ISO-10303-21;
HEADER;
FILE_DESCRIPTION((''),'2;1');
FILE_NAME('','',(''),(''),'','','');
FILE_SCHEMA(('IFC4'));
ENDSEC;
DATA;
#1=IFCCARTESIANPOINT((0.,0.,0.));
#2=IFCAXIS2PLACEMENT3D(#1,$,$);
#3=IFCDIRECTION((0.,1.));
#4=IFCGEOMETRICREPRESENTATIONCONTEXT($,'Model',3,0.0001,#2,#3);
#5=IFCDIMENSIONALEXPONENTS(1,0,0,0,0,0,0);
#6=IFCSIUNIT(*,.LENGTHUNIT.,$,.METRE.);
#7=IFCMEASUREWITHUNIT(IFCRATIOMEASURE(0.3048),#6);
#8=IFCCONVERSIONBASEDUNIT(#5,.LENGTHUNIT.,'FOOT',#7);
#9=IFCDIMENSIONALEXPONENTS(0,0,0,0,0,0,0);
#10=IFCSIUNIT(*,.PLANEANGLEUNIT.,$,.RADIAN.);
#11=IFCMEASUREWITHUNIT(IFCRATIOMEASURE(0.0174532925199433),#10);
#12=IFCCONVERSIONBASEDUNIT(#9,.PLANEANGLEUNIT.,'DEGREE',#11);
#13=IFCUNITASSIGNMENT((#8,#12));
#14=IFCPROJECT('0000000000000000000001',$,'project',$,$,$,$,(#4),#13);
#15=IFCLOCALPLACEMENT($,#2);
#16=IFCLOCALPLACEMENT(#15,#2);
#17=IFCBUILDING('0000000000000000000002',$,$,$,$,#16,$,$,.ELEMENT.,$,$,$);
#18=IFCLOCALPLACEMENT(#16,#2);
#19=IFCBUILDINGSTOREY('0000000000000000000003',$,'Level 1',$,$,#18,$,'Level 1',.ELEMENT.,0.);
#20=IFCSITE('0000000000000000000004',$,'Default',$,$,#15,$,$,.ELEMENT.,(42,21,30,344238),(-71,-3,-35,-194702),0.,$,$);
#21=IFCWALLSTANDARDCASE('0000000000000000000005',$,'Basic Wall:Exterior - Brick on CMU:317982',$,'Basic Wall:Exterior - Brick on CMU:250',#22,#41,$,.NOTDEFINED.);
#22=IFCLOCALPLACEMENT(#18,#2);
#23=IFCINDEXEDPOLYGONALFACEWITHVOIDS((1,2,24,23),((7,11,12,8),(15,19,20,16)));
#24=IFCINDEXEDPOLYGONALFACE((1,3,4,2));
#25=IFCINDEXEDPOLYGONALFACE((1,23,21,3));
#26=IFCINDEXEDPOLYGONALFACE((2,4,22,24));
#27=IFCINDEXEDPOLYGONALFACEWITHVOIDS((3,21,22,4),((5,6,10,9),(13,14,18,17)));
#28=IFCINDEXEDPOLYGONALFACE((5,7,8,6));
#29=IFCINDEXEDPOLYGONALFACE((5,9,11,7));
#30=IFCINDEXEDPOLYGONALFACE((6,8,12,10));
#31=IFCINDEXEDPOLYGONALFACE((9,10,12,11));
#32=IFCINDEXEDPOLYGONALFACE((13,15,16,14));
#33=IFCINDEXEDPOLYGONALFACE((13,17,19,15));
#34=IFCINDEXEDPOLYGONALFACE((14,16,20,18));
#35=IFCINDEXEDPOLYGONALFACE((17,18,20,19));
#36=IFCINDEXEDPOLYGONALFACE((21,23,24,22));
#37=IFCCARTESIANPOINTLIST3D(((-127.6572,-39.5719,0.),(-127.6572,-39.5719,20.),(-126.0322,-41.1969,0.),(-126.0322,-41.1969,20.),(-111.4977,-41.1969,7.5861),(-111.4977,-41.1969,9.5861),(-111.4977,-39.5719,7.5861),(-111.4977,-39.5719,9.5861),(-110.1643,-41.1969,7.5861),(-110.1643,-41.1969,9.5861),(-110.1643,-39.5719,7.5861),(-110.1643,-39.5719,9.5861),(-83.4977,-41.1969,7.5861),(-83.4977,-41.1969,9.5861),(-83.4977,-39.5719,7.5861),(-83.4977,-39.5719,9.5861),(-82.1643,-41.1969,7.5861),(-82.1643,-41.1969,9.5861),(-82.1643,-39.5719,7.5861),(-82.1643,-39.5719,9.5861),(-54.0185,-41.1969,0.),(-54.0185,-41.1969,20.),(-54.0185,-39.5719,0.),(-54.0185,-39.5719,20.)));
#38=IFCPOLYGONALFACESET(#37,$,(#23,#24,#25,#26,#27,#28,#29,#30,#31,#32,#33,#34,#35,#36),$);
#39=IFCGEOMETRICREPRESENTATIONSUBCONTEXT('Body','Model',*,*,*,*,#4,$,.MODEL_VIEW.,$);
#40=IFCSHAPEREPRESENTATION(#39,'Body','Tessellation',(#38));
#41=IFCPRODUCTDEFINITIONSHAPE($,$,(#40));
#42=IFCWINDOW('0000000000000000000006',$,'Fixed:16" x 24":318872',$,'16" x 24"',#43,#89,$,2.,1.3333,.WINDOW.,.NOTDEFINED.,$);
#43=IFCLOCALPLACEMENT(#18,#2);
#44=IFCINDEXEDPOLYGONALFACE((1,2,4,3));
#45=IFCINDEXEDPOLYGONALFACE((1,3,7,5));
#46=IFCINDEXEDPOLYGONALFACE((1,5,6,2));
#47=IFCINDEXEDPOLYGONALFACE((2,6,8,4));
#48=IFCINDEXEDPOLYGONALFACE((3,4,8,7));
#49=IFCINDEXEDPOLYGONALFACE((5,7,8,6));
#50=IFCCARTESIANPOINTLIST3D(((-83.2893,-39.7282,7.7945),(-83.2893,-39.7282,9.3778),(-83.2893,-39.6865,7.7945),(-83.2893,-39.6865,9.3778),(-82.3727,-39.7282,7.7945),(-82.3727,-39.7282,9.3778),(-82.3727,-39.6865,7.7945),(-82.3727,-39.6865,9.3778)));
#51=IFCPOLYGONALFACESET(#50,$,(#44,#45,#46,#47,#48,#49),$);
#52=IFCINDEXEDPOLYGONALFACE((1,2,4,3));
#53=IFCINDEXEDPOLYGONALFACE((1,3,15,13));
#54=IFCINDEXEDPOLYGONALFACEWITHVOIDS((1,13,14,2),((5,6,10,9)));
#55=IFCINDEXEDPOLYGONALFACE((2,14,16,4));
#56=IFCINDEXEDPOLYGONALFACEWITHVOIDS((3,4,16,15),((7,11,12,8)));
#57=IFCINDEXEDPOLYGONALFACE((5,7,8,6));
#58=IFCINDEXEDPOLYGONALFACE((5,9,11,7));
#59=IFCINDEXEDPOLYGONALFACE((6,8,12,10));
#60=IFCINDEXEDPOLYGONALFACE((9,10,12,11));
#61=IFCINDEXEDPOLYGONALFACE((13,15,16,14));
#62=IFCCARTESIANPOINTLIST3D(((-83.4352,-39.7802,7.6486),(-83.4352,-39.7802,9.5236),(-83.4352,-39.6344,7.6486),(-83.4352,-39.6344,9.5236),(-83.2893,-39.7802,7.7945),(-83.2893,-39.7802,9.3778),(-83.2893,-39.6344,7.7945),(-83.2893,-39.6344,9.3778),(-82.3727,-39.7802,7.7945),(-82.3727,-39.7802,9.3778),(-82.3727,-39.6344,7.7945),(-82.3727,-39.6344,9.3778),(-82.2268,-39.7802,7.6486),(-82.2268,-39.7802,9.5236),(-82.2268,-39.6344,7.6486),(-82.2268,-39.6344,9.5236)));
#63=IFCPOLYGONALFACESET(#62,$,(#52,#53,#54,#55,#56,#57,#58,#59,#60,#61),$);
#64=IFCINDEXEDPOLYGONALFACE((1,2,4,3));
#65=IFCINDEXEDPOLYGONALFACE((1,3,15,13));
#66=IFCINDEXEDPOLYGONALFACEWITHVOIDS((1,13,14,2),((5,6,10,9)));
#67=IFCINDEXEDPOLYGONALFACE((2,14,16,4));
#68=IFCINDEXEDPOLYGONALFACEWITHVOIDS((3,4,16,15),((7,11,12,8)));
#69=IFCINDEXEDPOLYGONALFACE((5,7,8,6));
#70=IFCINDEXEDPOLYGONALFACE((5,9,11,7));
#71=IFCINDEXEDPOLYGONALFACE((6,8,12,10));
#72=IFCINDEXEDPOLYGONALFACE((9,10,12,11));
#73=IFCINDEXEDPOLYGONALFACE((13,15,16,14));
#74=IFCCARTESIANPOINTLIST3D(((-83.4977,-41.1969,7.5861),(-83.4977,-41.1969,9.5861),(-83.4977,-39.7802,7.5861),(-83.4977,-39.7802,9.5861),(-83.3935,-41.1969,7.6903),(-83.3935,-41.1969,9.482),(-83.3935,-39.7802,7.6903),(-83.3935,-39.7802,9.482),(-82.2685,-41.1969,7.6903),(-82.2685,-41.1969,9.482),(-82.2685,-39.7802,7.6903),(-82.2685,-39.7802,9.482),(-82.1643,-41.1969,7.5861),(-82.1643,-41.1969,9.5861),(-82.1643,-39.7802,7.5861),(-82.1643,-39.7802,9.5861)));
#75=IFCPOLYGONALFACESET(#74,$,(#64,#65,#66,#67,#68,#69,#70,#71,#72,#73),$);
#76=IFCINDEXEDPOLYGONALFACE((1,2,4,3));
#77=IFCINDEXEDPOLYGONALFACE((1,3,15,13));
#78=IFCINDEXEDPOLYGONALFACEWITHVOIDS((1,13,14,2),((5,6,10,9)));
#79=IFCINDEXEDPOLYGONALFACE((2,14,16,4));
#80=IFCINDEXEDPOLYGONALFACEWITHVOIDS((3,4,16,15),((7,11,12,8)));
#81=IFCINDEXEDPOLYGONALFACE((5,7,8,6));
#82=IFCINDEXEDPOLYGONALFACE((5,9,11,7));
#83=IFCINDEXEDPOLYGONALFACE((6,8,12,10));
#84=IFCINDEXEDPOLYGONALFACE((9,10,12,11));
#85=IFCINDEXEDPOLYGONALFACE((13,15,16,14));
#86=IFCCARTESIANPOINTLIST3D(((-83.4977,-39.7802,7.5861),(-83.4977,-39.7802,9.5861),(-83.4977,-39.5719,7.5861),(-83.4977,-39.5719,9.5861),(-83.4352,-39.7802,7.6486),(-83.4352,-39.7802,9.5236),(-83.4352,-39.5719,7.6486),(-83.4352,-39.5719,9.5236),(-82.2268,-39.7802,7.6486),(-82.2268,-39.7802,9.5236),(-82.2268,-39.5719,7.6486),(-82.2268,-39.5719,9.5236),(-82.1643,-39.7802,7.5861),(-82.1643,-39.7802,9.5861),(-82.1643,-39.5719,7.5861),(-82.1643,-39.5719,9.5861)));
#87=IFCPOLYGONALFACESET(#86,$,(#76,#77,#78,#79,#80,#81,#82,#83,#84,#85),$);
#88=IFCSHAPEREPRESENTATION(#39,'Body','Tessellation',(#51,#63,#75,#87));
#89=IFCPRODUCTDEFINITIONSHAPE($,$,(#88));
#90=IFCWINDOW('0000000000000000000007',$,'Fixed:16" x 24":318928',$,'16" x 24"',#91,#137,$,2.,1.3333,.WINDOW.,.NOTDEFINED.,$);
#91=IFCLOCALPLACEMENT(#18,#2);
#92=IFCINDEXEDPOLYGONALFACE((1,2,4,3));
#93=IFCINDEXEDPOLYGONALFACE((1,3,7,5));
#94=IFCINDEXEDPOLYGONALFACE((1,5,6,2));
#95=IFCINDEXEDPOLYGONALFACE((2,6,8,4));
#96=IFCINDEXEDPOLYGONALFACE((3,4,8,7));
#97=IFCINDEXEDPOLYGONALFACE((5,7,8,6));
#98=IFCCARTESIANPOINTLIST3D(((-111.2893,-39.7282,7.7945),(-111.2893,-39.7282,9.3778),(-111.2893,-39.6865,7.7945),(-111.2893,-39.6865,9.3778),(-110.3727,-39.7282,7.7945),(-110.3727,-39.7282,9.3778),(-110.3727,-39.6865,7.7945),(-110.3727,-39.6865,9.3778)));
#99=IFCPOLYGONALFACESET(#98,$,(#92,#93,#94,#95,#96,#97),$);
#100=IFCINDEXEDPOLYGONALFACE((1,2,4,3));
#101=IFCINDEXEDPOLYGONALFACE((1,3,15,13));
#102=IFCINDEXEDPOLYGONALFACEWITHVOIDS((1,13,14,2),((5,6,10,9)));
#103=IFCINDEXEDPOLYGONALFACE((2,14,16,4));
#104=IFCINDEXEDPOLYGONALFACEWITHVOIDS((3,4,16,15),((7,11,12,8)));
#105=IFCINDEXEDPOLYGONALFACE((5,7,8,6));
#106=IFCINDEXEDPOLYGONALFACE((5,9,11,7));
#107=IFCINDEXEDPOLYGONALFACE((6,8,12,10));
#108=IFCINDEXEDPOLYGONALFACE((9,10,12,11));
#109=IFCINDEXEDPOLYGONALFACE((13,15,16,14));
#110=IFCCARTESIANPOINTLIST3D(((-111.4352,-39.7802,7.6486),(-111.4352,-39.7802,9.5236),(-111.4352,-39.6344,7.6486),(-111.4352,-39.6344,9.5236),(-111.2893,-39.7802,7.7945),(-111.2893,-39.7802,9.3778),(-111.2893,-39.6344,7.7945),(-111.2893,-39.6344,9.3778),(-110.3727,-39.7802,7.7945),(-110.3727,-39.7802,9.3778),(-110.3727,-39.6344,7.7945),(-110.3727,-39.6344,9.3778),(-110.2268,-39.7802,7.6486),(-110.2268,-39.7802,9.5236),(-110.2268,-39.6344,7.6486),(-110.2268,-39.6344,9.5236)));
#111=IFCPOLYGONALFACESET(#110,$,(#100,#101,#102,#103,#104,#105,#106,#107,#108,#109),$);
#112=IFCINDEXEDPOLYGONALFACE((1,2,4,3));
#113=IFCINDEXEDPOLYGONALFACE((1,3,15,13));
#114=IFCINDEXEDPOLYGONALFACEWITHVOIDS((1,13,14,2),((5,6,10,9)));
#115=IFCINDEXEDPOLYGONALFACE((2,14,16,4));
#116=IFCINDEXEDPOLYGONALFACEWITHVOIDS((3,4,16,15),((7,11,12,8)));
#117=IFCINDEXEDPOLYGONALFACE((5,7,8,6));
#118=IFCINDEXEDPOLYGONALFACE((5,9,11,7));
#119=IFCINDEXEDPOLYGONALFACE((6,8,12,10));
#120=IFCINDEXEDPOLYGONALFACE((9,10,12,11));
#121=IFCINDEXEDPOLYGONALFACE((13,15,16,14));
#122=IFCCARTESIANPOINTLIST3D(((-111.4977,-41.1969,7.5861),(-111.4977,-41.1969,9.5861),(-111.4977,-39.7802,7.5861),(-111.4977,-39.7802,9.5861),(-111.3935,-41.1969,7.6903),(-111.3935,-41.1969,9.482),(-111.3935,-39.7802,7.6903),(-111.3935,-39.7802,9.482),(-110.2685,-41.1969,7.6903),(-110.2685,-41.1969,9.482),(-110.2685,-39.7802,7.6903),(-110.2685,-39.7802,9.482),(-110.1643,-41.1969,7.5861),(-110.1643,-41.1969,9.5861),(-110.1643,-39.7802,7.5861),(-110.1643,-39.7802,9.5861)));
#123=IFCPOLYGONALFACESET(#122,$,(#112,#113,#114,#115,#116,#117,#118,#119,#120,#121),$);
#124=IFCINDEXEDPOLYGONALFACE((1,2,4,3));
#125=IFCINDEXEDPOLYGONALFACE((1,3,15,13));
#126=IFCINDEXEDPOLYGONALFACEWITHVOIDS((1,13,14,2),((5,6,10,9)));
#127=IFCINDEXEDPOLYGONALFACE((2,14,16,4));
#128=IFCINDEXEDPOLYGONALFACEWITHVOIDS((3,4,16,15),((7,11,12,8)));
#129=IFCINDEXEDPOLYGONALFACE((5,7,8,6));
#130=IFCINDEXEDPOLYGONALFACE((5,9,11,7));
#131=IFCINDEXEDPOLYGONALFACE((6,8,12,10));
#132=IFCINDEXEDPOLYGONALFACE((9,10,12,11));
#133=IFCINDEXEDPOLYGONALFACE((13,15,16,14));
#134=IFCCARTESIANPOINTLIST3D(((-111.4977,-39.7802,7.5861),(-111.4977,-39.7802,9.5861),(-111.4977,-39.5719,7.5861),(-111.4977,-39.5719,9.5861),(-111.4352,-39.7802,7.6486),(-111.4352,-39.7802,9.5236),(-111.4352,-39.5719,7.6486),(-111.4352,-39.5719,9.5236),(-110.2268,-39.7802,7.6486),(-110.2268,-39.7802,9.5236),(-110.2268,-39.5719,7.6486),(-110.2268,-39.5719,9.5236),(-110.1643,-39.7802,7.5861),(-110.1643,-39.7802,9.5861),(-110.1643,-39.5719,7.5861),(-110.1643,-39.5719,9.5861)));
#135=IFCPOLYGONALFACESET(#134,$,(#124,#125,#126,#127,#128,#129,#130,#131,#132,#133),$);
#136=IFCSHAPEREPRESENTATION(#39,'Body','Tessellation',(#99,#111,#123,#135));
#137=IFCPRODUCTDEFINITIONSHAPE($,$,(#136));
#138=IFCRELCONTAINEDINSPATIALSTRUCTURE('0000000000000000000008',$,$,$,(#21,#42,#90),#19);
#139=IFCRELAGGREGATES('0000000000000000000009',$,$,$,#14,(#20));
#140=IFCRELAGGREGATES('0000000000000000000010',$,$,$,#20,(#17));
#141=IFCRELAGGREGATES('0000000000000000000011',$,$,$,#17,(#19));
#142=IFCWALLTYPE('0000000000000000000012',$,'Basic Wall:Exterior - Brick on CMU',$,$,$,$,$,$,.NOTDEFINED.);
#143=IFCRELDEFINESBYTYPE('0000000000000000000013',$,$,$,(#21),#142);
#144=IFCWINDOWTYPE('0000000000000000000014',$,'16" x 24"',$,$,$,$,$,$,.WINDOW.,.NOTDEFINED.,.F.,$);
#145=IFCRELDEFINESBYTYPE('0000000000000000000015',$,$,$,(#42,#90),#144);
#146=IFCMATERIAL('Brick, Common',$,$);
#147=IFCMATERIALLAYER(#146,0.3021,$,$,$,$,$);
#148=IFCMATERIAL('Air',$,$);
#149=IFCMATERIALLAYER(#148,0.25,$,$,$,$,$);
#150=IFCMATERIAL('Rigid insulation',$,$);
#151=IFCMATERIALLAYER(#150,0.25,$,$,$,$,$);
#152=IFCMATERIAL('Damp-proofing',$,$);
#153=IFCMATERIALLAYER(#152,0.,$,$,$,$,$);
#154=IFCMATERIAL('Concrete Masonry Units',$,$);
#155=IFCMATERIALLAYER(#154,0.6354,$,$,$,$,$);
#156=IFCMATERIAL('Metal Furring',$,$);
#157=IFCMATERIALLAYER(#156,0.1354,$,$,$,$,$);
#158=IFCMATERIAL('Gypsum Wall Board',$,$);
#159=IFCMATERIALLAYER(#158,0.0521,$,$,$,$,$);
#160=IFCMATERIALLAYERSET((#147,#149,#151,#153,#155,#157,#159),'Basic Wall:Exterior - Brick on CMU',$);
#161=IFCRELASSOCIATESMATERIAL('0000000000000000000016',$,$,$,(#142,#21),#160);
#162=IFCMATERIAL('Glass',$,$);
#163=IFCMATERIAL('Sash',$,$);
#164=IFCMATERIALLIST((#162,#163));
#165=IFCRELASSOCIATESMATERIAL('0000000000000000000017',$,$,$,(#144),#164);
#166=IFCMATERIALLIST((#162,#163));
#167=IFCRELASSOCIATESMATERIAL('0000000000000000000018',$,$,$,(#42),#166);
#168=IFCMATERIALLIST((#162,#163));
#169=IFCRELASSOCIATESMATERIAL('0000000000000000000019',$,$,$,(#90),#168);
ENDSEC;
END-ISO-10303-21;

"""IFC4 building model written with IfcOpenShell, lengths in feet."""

from ifc_helpers import new_model, entity, si_unit, converted_unit, direction, frame, frame_2d, origin, place, context, subcontext, project, spatial, polyline, rectangle, outline, extrude, source, transform, mapped, material, material_list, layer, layer_set, layer_usage, type_object, type_shapes, element, fill, save


model = new_model("IFC4")

# Units and contexts
model_context = context("Model", 3, precision=0.0001, world=origin(), true_north=direction((0.0, 1.0)))
body_context = subcontext(model_context, "Body", "Model", "MODEL_VIEW")
ifc_project = project(units=[converted_unit("LENGTHUNIT", "FOOT", entity("IfcRatioMeasure", 0.3048), si_unit("LENGTHUNIT", "METRE"), dimensions=[1, 0, 0, 0, 0, 0, 0]), converted_unit("PLANEANGLEUNIT", "DEGREE", entity("IfcRatioMeasure", 0.0174532925199433), si_unit("PLANEANGLEUNIT", "RADIAN"), dimensions=[0, 0, 0, 0, 0, 0, 0])], contexts=[model_context])

# Site, building, storey
site_placement = place(None, origin())
site = spatial("IfcSite", under=ifc_project, at=site_placement, Name="Default", CompositionType="ELEMENT", RefLatitude=(42, 21, 30, 344238), RefLongitude=(-71, -3, -35, -194702), RefElevation=0.0)
building_placement = place(site_placement, origin())
building = spatial("IfcBuilding", under=site, at=building_placement, CompositionType="ELEMENT")
storey_placement = place(building_placement, origin())
storey = spatial("IfcBuildingStorey", under=building, at=storey_placement, Name="Level 1", LongName="Level 1", CompositionType="ELEMENT", Elevation=0.0)

# Shared definitions
ifc_material_1 = material(Name="Brick, Common")
ifc_layer_1 = layer(ifc_material_1, 0.3021)
ifc_material_2 = material(Name="Air")
ifc_layer_2 = layer(ifc_material_2, 0.25)
ifc_material_3 = material(Name="Rigid insulation")
ifc_layer_3 = layer(ifc_material_3, 0.25)
ifc_material_4 = material(Name="Damp-proofing")
ifc_layer_4 = layer(ifc_material_4, 0.0)
ifc_material_5 = material(Name="Concrete Masonry Units")
ifc_layer_5 = layer(ifc_material_5, 0.6354)
ifc_material_6 = material(Name="Metal Furring")
ifc_layer_6 = layer(ifc_material_6, 0.1354)
ifc_material_7 = material(Name="Gypsum Wall Board")
ifc_layer_7 = layer(ifc_material_7, 0.0521)
ifc_layer_set = layer_set([ifc_layer_1, ifc_layer_2, ifc_layer_3, ifc_layer_4, ifc_layer_5, ifc_layer_6, ifc_layer_7], Name="Basic Wall:Exterior - Brick on CMU")
wall_type = type_object("IfcWallType", Name="Basic Wall:Exterior - Brick on CMU", PredefinedType="NOTDEFINED", material=ifc_layer_set)

# Wall, openings, windows
ifc_layer_usage_1 = layer_usage(ifc_layer_set, "AXIS2", "NEGATIVE", 0.8125)
wall_1_placement = place(storey_placement, frame((-127.6572, -40.3844, 0.0)))
wall_1 = element("IfcWallStandardCase", 1, at=wall_1_placement, inside=storey, type_object=wall_type, material=ifc_layer_usage_1, Name="Basic Wall:Exterior - Brick on CMU:317982", ObjectType="Basic Wall:Exterior - Brick on CMU:250", PredefinedType="NOTDEFINED", context=body_context, shape_type="SweptSolid", body=[
    extrude(outline(polyline([(73.6387, -0.8125), (73.6387, 0.8125), (0.0, 0.8125), (1.625, -0.8125), (72.0137, -0.8125), (73.6387, -0.8125)])), origin(), (0.0, 0.0, 1.0), 20.0),
])
opening_1_placement = place(wall_1_placement, frame((44.1595, -0.8125, 7.5861)))
opening_1 = element("IfcOpeningElement", 2, at=opening_1_placement, cuts=wall_1, ObjectType="Opening", PredefinedType="OPENING", context=body_context, shape_type="SweptSolid", body=[
    extrude(rectangle(XDim=2.0, YDim=1.3333, at=frame_2d((1.0, 0.6667), x_axis=(-1.0, 0.0))), frame((0.0, 0.0, 0.0), z_axis=(0.0, 1.0, 0.0), x_axis=(0.0, 0.0, 1.0)), (0.0, 0.0, 1.0), 1.625),
])
opening_2_placement = place(wall_1_placement, frame((16.1595, -0.8125, 7.5861)))
opening_2 = element("IfcOpeningElement", 3, at=opening_2_placement, cuts=wall_1, ObjectType="Opening", PredefinedType="OPENING", context=body_context, shape_type="SweptSolid", body=[
    extrude(rectangle(XDim=2.0, YDim=1.3333, at=frame_2d((1.0, 0.6667), x_axis=(-1.0, 0.0))), frame((0.0, 0.0, 0.0), z_axis=(0.0, 1.0, 0.0), x_axis=(0.0, 0.0, 1.0)), (0.0, 0.0, 1.0), 1.625),
])
ifc_material_8 = material(Name="Glass")
ifc_material_9 = material(Name="Sash")
ifc_material_list_1 = material_list([ifc_material_8, ifc_material_9])
ifc_material_list_2 = material_list([ifc_material_8, ifc_material_9])
window_type = type_object("IfcWindowType", Name="16\" x 24\"", ParameterTakesPrecedence=False, PartitioningType="NOTDEFINED", PredefinedType="WINDOW", material=ifc_material_list_2)
shared_shape_1 = source(origin(), body_context, "Body", "SweptSolid", [
    extrude(rectangle(XDim=0.0417, YDim=0.9167, at=frame_2d((0.0, 0.0), x_axis=(1.0, 0.0))), frame((0.6667, 1.4896, 0.2083), z_axis=(0.0, 0.0, 1.0), x_axis=(0.0, 1.0, 0.0)), (0.0, 0.0, 1.0), 1.5833),
    extrude(outline(polyline([(-0.6042, -0.9375), (0.6042, -0.9375), (0.6042, 0.9375), (-0.6042, 0.9375), (-0.6042, -0.9375)]), holes=[polyline([(-0.4583, -0.7917), (-0.4583, 0.7917), (0.4583, 0.7917), (0.4583, -0.7917), (-0.4583, -0.7917)])]), frame((0.6667, 1.4167, 1.0), z_axis=(0.0, 1.0, 0.0), x_axis=(1.0, 0.0, 0.0)), (0.0, 0.0, 1.0), 0.1458),
    extrude(outline(polyline([(-0.6667, -1.0), (0.6667, -1.0), (0.6667, 1.0), (-0.6667, 1.0), (-0.6667, -1.0)]), holes=[polyline([(-0.5625, -0.8958), (-0.5625, 0.8958), (0.5625, 0.8958), (0.5625, -0.8958), (-0.5625, -0.8958)])]), frame((0.6667, 0.0, 1.0), z_axis=(0.0, 1.0, 0.0), x_axis=(1.0, 0.0, 0.0)), (0.0, 0.0, 1.0), 1.4167),
    extrude(outline(polyline([(-1.0, -0.6667), (1.0, -0.6667), (1.0, 0.6667), (-1.0, 0.6667), (-1.0, -0.6667)]), holes=[polyline([(-0.9375, -0.6042), (-0.9375, 0.6042), (0.9375, 0.6042), (0.9375, -0.6042), (-0.9375, -0.6042)])]), frame((0.6667, 1.4167, 1.0), z_axis=(0.0, 1.0, 0.0), x_axis=(0.0, 0.0, -1.0)), (0.0, 0.0, 1.0), 0.2083),
])
type_shapes(window_type, [shared_shape_1])
window_1_placement = place(opening_1_placement, origin())
window_1 = element("IfcWindow", 4, at=window_1_placement, inside=storey, type_object=window_type, material=ifc_material_list_1, Name="Fixed:16\" x 24\":318872", ObjectType="16\" x 24\"", OverallHeight=2.0, OverallWidth=1.3333, PartitioningType="NOTDEFINED", PredefinedType="WINDOW", context=body_context, shape_type="MappedRepresentation", body=[
    mapped(shared_shape_1, transform((0.0, 0.0, 0.0), scale=1.0)),
])
fill(opening_1, window_1)
ifc_material_list_3 = material_list([ifc_material_8, ifc_material_9])
window_2_placement = place(opening_2_placement, origin())
window_2 = element("IfcWindow", 5, at=window_2_placement, inside=storey, type_object=window_type, material=ifc_material_list_3, Name="Fixed:16\" x 24\":318928", ObjectType="16\" x 24\"", OverallHeight=2.0, OverallWidth=1.3333, PartitioningType="NOTDEFINED", PredefinedType="WINDOW", context=body_context, shape_type="MappedRepresentation", body=[
    mapped(shared_shape_1, transform((0.0, 0.0, 0.0), scale=1.0)),
])
fill(opening_2, window_2)

save(model, "model.ifc")
